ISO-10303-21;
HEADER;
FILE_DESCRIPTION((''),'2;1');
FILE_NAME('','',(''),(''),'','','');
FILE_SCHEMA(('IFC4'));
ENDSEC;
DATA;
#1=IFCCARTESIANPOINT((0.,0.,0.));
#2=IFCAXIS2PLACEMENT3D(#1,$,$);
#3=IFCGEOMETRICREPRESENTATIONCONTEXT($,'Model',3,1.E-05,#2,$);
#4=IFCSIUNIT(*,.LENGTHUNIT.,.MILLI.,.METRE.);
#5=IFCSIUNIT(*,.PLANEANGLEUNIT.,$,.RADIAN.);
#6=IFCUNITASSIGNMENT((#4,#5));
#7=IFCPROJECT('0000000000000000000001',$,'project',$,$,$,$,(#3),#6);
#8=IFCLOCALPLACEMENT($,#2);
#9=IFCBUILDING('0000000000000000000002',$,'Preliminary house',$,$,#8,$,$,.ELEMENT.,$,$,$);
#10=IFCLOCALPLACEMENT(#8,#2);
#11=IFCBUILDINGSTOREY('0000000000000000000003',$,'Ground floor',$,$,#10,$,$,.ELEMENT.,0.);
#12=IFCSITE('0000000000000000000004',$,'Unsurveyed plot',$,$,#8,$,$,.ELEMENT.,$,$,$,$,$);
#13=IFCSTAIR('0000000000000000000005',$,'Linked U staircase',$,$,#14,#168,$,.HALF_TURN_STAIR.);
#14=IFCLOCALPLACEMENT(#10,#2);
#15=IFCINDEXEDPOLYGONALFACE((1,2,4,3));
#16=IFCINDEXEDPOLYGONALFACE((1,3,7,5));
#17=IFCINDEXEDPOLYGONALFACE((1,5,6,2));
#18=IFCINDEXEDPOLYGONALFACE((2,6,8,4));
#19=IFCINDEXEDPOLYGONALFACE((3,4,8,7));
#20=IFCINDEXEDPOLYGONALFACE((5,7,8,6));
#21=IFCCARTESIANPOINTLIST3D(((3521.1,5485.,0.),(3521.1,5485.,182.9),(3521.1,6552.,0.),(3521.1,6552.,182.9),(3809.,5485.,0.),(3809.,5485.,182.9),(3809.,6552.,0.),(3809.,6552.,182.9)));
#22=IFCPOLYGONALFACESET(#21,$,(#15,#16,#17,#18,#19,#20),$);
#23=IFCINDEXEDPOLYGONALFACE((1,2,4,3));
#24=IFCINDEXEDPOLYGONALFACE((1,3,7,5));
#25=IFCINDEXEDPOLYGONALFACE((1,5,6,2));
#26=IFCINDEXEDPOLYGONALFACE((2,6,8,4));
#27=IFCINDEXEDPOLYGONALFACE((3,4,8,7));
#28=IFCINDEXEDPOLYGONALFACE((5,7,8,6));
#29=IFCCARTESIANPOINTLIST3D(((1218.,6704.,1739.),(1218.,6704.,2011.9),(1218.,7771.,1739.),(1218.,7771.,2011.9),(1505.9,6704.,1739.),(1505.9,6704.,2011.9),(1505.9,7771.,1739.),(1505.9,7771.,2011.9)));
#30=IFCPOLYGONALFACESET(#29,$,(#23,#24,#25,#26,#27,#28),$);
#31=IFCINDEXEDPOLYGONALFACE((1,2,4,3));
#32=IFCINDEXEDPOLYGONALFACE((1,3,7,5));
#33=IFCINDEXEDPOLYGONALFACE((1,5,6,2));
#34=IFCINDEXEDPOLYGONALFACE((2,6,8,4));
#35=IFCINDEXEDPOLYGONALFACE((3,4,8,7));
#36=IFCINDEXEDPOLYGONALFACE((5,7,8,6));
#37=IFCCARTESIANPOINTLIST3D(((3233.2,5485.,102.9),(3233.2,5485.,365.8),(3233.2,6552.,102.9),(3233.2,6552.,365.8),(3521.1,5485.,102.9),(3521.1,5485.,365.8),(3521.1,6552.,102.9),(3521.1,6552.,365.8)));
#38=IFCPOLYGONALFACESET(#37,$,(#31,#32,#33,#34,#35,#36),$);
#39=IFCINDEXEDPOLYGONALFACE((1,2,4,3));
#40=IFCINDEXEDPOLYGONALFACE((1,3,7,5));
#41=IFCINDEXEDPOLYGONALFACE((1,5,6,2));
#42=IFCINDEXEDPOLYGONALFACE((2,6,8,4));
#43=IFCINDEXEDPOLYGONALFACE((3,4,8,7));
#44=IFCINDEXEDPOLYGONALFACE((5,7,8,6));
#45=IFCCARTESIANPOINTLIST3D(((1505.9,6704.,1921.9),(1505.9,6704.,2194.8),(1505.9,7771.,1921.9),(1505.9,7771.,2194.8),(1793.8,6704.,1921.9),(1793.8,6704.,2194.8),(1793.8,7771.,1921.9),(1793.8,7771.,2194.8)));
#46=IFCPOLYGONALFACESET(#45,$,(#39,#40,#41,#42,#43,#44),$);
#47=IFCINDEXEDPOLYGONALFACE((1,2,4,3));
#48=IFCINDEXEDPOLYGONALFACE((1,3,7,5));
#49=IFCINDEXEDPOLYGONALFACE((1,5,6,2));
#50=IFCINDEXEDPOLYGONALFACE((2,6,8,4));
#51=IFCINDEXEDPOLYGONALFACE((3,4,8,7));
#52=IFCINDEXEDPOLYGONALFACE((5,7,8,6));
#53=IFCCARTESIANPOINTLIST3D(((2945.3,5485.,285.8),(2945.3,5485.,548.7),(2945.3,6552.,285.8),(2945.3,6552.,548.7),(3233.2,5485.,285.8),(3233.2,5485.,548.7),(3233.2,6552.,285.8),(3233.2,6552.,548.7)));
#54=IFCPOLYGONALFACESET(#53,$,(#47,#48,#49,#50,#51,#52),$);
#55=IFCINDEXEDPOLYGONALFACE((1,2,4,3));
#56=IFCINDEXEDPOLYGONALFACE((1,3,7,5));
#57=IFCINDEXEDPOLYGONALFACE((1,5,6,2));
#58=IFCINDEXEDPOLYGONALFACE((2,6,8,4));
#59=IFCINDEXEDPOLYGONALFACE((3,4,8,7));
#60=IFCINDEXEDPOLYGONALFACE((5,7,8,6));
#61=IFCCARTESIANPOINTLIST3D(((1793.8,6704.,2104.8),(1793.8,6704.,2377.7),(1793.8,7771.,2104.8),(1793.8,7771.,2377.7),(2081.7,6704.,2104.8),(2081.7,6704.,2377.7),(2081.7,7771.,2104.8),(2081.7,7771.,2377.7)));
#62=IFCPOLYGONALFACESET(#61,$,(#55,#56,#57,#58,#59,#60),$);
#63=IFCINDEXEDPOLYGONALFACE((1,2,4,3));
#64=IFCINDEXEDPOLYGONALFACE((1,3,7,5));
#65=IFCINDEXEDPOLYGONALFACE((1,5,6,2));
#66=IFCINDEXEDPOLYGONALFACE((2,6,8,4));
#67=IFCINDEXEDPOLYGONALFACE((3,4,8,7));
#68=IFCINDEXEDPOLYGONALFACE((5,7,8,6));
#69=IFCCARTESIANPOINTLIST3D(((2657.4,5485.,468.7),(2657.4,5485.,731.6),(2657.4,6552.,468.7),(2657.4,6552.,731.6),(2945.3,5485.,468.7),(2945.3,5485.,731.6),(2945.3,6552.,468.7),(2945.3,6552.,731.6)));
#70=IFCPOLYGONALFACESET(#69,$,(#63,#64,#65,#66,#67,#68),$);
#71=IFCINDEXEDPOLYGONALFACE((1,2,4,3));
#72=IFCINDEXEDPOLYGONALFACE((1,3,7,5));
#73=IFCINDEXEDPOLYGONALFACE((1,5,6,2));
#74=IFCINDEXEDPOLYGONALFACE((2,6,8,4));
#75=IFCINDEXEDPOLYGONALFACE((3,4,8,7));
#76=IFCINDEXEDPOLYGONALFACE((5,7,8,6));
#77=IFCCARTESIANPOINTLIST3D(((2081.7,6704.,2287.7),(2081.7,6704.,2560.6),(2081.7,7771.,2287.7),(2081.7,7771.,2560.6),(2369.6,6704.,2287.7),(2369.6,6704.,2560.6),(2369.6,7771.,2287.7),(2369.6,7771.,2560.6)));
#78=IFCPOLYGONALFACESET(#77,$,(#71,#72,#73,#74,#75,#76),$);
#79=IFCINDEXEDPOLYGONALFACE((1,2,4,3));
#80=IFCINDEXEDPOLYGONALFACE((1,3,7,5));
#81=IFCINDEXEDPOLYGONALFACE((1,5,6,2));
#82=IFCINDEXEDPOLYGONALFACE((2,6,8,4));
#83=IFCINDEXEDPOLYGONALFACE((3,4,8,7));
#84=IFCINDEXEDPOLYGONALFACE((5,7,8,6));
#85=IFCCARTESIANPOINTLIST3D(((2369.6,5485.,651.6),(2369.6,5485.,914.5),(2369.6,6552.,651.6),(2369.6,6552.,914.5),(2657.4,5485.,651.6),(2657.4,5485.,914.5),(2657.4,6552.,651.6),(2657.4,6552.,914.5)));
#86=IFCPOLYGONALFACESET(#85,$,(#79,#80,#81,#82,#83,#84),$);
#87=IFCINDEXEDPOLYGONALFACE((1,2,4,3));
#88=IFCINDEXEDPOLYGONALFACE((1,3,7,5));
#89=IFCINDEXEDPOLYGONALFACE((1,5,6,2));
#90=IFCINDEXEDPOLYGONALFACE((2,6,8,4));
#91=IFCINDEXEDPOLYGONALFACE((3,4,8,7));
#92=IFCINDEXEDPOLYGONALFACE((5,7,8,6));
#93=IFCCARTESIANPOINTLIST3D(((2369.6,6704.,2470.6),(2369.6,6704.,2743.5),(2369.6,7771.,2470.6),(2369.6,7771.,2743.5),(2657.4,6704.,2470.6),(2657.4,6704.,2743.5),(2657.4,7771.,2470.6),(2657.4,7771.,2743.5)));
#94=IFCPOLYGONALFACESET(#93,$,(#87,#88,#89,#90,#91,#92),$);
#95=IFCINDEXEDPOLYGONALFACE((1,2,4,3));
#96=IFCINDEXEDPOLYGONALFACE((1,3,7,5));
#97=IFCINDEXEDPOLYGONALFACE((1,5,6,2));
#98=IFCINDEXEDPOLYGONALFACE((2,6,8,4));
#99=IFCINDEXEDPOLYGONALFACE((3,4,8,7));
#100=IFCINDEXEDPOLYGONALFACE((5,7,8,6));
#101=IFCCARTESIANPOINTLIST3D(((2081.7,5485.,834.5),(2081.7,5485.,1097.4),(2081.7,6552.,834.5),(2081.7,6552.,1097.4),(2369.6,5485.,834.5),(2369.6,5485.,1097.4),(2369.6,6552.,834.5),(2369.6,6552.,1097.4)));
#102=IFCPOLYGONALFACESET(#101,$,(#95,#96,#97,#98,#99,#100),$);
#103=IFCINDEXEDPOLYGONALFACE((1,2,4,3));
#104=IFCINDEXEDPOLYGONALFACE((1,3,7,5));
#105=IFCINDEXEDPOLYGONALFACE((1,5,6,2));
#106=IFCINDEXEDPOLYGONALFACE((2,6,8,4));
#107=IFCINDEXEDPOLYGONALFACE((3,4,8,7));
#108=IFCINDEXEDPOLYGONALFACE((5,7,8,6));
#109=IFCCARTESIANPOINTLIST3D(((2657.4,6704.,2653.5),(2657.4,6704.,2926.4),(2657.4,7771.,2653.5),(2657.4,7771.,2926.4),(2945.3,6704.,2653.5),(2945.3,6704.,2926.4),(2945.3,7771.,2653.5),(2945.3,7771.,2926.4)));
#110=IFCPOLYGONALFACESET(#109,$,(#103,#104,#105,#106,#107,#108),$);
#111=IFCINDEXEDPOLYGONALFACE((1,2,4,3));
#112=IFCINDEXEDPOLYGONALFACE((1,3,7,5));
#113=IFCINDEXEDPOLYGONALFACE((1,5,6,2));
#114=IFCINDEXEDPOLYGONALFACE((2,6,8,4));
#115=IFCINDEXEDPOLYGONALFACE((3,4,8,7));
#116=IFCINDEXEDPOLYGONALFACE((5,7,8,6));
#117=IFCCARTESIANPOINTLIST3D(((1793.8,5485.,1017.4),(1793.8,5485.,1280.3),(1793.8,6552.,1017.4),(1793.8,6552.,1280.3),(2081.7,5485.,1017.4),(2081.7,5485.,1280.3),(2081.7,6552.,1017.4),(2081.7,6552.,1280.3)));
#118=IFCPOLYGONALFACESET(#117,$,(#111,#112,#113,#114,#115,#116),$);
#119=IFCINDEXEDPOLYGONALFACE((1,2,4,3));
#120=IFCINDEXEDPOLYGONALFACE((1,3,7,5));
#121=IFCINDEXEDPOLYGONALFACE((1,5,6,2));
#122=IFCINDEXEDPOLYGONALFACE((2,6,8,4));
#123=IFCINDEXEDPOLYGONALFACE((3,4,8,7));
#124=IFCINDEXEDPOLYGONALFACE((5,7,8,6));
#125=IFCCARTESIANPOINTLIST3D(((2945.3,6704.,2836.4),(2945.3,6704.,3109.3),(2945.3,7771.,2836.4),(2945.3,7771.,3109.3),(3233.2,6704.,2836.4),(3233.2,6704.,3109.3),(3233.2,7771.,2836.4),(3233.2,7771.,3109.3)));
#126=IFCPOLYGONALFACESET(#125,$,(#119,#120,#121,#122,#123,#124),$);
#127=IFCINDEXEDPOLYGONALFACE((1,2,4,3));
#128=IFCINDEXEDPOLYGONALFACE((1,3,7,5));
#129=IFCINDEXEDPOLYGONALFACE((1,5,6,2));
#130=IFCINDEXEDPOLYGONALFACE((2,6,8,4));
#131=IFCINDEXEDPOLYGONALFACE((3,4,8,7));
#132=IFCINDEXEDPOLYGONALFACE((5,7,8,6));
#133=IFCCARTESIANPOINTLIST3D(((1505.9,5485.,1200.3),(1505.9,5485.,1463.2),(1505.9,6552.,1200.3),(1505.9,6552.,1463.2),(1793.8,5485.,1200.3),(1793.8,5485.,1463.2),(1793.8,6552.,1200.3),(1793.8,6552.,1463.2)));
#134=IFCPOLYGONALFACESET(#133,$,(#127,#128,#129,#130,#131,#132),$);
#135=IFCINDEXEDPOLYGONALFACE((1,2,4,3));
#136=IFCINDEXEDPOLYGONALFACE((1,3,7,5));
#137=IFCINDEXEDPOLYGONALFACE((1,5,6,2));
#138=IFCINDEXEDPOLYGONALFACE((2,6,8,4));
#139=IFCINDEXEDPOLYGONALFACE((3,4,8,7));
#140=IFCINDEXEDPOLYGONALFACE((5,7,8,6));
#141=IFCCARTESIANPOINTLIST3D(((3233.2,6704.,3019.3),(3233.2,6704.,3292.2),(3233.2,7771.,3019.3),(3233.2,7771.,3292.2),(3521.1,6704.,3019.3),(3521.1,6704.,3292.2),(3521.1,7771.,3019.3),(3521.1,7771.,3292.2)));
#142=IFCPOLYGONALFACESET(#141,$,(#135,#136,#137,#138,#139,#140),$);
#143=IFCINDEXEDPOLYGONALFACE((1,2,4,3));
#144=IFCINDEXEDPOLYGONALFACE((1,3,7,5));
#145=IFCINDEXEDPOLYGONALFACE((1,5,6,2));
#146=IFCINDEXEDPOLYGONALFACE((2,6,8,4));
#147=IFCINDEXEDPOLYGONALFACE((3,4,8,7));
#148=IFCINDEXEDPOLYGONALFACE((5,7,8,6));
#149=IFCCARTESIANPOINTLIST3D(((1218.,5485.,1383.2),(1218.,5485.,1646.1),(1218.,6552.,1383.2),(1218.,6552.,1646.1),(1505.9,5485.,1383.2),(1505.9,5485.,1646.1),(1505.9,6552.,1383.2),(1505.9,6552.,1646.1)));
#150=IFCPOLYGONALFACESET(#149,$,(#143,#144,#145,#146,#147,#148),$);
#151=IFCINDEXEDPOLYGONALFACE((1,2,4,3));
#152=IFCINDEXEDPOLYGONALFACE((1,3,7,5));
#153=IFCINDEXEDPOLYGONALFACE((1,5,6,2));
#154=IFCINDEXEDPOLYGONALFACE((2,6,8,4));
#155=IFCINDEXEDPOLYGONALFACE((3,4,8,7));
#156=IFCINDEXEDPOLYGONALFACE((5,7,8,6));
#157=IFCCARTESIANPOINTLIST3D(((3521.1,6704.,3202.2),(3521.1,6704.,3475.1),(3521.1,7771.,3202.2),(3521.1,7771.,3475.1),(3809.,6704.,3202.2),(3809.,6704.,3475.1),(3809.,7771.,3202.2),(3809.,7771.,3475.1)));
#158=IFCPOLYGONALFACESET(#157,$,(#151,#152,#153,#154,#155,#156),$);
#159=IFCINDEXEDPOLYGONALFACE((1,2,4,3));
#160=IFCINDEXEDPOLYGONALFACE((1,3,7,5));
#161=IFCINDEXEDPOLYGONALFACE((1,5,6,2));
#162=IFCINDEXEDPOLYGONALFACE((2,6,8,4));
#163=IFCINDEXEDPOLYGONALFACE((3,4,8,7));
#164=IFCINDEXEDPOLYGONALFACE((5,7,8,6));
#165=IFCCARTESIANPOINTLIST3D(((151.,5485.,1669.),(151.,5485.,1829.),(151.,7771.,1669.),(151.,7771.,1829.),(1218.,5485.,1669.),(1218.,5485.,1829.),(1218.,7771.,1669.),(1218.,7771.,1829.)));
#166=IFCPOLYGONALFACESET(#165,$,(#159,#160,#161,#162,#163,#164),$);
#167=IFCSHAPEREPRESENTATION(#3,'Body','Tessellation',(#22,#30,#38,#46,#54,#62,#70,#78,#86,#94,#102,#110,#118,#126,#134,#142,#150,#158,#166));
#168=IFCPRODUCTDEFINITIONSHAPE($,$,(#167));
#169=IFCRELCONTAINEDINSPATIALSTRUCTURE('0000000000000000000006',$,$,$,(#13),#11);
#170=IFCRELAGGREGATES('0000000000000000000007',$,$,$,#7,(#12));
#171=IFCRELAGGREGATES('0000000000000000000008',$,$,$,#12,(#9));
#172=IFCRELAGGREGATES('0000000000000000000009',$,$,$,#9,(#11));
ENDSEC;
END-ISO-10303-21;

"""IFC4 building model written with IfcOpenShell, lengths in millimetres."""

from ifc_helpers import new_model, si_unit, frame, origin, place, context, project, spatial, polyline, outline, extrude, element, save


model = new_model("IFC4")

# Units and contexts
model_context = context("Model", 3, precision=1e-05, world=origin())
ifc_project = project(units=[si_unit("LENGTHUNIT", "METRE", prefix="MILLI"), si_unit("PLANEANGLEUNIT", "RADIAN")], contexts=[model_context])

# Site, building, storey
placement_1 = place(None, origin())
site = spatial("IfcSite", under=ifc_project, at=placement_1, Name="Unsurveyed plot", CompositionType="ELEMENT")
building = spatial("IfcBuilding", under=site, at=placement_1, Name="Preliminary house", CompositionType="ELEMENT")
placement_2 = place(placement_1, origin())
storey = spatial("IfcBuildingStorey", under=building, at=placement_2, Name="Ground floor", CompositionType="ELEMENT", Elevation=0.0)

# Stair
element("IfcStair", 1, at=placement_2, inside=storey, Name="Linked U staircase", PredefinedType="HALF_TURN_STAIR", context=model_context, shape_type="SweptSolid", body=[
    extrude(outline(polyline([(3809.0, 6552.0), (3521.1, 6552.0), (3521.1, 5485.0), (3809.0, 5485.0), (3809.0, 6552.0)])), origin(), (0.0, 0.0, 1.0), 182.9),
    extrude(outline(polyline([(1505.9, 7771.0), (1218.0, 7771.0), (1218.0, 6704.0), (1505.9, 6704.0), (1505.9, 7771.0)])), frame((0.0, 0.0, 1739.0)), (0.0, 0.0, 1.0), 272.9),
    extrude(outline(polyline([(3521.1, 6552.0), (3233.2, 6552.0), (3233.2, 5485.0), (3521.1, 5485.0), (3521.1, 6552.0)])), frame((0.0, 0.0, 102.9)), (0.0, 0.0, 1.0), 262.9),
    extrude(outline(polyline([(1793.8, 7771.0), (1505.9, 7771.0), (1505.9, 6704.0), (1793.8, 6704.0), (1793.8, 7771.0)])), frame((0.0, 0.0, 1921.9)), (0.0, 0.0, 1.0), 272.9),
    extrude(outline(polyline([(3233.2, 6552.0), (2945.3, 6552.0), (2945.3, 5485.0), (3233.2, 5485.0), (3233.2, 6552.0)])), frame((0.0, 0.0, 285.8)), (0.0, 0.0, 1.0), 262.9),
    extrude(outline(polyline([(2081.7, 7771.0), (1793.8, 7771.0), (1793.8, 6704.0), (2081.7, 6704.0), (2081.7, 7771.0)])), frame((0.0, 0.0, 2104.8)), (0.0, 0.0, 1.0), 272.9),
    extrude(outline(polyline([(2945.3, 6552.0), (2657.4, 6552.0), (2657.4, 5485.0), (2945.3, 5485.0), (2945.3, 6552.0)])), frame((0.0, 0.0, 468.7)), (0.0, 0.0, 1.0), 262.9),
    extrude(outline(polyline([(2369.6, 7771.0), (2081.7, 7771.0), (2081.7, 6704.0), (2369.6, 6704.0), (2369.6, 7771.0)])), frame((0.0, 0.0, 2287.7)), (0.0, 0.0, 1.0), 272.9),
    extrude(outline(polyline([(2657.4, 6552.0), (2369.6, 6552.0), (2369.6, 5485.0), (2657.4, 5485.0), (2657.4, 6552.0)])), frame((0.0, 0.0, 651.6)), (0.0, 0.0, 1.0), 262.9),
    extrude(outline(polyline([(2657.4, 7771.0), (2369.6, 7771.0), (2369.6, 6704.0), (2657.4, 6704.0), (2657.4, 7771.0)])), frame((0.0, 0.0, 2470.6)), (0.0, 0.0, 1.0), 272.9),
    extrude(outline(polyline([(2369.6, 6552.0), (2081.7, 6552.0), (2081.7, 5485.0), (2369.6, 5485.0), (2369.6, 6552.0)])), frame((0.0, 0.0, 834.5)), (0.0, 0.0, 1.0), 262.9),
    extrude(outline(polyline([(2945.3, 7771.0), (2657.4, 7771.0), (2657.4, 6704.0), (2945.3, 6704.0), (2945.3, 7771.0)])), frame((0.0, 0.0, 2653.5)), (0.0, 0.0, 1.0), 272.9),
    extrude(outline(polyline([(2081.7, 6552.0), (1793.8, 6552.0), (1793.8, 5485.0), (2081.7, 5485.0), (2081.7, 6552.0)])), frame((0.0, 0.0, 1017.4)), (0.0, 0.0, 1.0), 262.9),
    extrude(outline(polyline([(3233.2, 7771.0), (2945.3, 7771.0), (2945.3, 6704.0), (3233.2, 6704.0), (3233.2, 7771.0)])), frame((0.0, 0.0, 2836.4)), (0.0, 0.0, 1.0), 272.9),
    extrude(outline(polyline([(1793.8, 6552.0), (1505.9, 6552.0), (1505.9, 5485.0), (1793.8, 5485.0), (1793.8, 6552.0)])), frame((0.0, 0.0, 1200.3)), (0.0, 0.0, 1.0), 262.9),
    extrude(outline(polyline([(3521.1, 7771.0), (3233.2, 7771.0), (3233.2, 6704.0), (3521.1, 6704.0), (3521.1, 7771.0)])), frame((0.0, 0.0, 3019.3)), (0.0, 0.0, 1.0), 272.9),
    extrude(outline(polyline([(1505.9, 6552.0), (1218.0, 6552.0), (1218.0, 5485.0), (1505.9, 5485.0), (1505.9, 6552.0)])), frame((0.0, 0.0, 1383.2)), (0.0, 0.0, 1.0), 262.9),
    extrude(outline(polyline([(3809.0, 7771.0), (3521.1, 7771.0), (3521.1, 6704.0), (3809.0, 6704.0), (3809.0, 7771.0)])), frame((0.0, 0.0, 3202.2)), (0.0, 0.0, 1.0), 272.9),
    extrude(outline(polyline([(1218.0, 7771.0), (151.0, 7771.0), (151.0, 5485.0), (1218.0, 5485.0), (1218.0, 7771.0)])), frame((0.0, 0.0, 1669.0)), (0.0, 0.0, 1.0), 160.0),
])

save(model, "model.ifc")
